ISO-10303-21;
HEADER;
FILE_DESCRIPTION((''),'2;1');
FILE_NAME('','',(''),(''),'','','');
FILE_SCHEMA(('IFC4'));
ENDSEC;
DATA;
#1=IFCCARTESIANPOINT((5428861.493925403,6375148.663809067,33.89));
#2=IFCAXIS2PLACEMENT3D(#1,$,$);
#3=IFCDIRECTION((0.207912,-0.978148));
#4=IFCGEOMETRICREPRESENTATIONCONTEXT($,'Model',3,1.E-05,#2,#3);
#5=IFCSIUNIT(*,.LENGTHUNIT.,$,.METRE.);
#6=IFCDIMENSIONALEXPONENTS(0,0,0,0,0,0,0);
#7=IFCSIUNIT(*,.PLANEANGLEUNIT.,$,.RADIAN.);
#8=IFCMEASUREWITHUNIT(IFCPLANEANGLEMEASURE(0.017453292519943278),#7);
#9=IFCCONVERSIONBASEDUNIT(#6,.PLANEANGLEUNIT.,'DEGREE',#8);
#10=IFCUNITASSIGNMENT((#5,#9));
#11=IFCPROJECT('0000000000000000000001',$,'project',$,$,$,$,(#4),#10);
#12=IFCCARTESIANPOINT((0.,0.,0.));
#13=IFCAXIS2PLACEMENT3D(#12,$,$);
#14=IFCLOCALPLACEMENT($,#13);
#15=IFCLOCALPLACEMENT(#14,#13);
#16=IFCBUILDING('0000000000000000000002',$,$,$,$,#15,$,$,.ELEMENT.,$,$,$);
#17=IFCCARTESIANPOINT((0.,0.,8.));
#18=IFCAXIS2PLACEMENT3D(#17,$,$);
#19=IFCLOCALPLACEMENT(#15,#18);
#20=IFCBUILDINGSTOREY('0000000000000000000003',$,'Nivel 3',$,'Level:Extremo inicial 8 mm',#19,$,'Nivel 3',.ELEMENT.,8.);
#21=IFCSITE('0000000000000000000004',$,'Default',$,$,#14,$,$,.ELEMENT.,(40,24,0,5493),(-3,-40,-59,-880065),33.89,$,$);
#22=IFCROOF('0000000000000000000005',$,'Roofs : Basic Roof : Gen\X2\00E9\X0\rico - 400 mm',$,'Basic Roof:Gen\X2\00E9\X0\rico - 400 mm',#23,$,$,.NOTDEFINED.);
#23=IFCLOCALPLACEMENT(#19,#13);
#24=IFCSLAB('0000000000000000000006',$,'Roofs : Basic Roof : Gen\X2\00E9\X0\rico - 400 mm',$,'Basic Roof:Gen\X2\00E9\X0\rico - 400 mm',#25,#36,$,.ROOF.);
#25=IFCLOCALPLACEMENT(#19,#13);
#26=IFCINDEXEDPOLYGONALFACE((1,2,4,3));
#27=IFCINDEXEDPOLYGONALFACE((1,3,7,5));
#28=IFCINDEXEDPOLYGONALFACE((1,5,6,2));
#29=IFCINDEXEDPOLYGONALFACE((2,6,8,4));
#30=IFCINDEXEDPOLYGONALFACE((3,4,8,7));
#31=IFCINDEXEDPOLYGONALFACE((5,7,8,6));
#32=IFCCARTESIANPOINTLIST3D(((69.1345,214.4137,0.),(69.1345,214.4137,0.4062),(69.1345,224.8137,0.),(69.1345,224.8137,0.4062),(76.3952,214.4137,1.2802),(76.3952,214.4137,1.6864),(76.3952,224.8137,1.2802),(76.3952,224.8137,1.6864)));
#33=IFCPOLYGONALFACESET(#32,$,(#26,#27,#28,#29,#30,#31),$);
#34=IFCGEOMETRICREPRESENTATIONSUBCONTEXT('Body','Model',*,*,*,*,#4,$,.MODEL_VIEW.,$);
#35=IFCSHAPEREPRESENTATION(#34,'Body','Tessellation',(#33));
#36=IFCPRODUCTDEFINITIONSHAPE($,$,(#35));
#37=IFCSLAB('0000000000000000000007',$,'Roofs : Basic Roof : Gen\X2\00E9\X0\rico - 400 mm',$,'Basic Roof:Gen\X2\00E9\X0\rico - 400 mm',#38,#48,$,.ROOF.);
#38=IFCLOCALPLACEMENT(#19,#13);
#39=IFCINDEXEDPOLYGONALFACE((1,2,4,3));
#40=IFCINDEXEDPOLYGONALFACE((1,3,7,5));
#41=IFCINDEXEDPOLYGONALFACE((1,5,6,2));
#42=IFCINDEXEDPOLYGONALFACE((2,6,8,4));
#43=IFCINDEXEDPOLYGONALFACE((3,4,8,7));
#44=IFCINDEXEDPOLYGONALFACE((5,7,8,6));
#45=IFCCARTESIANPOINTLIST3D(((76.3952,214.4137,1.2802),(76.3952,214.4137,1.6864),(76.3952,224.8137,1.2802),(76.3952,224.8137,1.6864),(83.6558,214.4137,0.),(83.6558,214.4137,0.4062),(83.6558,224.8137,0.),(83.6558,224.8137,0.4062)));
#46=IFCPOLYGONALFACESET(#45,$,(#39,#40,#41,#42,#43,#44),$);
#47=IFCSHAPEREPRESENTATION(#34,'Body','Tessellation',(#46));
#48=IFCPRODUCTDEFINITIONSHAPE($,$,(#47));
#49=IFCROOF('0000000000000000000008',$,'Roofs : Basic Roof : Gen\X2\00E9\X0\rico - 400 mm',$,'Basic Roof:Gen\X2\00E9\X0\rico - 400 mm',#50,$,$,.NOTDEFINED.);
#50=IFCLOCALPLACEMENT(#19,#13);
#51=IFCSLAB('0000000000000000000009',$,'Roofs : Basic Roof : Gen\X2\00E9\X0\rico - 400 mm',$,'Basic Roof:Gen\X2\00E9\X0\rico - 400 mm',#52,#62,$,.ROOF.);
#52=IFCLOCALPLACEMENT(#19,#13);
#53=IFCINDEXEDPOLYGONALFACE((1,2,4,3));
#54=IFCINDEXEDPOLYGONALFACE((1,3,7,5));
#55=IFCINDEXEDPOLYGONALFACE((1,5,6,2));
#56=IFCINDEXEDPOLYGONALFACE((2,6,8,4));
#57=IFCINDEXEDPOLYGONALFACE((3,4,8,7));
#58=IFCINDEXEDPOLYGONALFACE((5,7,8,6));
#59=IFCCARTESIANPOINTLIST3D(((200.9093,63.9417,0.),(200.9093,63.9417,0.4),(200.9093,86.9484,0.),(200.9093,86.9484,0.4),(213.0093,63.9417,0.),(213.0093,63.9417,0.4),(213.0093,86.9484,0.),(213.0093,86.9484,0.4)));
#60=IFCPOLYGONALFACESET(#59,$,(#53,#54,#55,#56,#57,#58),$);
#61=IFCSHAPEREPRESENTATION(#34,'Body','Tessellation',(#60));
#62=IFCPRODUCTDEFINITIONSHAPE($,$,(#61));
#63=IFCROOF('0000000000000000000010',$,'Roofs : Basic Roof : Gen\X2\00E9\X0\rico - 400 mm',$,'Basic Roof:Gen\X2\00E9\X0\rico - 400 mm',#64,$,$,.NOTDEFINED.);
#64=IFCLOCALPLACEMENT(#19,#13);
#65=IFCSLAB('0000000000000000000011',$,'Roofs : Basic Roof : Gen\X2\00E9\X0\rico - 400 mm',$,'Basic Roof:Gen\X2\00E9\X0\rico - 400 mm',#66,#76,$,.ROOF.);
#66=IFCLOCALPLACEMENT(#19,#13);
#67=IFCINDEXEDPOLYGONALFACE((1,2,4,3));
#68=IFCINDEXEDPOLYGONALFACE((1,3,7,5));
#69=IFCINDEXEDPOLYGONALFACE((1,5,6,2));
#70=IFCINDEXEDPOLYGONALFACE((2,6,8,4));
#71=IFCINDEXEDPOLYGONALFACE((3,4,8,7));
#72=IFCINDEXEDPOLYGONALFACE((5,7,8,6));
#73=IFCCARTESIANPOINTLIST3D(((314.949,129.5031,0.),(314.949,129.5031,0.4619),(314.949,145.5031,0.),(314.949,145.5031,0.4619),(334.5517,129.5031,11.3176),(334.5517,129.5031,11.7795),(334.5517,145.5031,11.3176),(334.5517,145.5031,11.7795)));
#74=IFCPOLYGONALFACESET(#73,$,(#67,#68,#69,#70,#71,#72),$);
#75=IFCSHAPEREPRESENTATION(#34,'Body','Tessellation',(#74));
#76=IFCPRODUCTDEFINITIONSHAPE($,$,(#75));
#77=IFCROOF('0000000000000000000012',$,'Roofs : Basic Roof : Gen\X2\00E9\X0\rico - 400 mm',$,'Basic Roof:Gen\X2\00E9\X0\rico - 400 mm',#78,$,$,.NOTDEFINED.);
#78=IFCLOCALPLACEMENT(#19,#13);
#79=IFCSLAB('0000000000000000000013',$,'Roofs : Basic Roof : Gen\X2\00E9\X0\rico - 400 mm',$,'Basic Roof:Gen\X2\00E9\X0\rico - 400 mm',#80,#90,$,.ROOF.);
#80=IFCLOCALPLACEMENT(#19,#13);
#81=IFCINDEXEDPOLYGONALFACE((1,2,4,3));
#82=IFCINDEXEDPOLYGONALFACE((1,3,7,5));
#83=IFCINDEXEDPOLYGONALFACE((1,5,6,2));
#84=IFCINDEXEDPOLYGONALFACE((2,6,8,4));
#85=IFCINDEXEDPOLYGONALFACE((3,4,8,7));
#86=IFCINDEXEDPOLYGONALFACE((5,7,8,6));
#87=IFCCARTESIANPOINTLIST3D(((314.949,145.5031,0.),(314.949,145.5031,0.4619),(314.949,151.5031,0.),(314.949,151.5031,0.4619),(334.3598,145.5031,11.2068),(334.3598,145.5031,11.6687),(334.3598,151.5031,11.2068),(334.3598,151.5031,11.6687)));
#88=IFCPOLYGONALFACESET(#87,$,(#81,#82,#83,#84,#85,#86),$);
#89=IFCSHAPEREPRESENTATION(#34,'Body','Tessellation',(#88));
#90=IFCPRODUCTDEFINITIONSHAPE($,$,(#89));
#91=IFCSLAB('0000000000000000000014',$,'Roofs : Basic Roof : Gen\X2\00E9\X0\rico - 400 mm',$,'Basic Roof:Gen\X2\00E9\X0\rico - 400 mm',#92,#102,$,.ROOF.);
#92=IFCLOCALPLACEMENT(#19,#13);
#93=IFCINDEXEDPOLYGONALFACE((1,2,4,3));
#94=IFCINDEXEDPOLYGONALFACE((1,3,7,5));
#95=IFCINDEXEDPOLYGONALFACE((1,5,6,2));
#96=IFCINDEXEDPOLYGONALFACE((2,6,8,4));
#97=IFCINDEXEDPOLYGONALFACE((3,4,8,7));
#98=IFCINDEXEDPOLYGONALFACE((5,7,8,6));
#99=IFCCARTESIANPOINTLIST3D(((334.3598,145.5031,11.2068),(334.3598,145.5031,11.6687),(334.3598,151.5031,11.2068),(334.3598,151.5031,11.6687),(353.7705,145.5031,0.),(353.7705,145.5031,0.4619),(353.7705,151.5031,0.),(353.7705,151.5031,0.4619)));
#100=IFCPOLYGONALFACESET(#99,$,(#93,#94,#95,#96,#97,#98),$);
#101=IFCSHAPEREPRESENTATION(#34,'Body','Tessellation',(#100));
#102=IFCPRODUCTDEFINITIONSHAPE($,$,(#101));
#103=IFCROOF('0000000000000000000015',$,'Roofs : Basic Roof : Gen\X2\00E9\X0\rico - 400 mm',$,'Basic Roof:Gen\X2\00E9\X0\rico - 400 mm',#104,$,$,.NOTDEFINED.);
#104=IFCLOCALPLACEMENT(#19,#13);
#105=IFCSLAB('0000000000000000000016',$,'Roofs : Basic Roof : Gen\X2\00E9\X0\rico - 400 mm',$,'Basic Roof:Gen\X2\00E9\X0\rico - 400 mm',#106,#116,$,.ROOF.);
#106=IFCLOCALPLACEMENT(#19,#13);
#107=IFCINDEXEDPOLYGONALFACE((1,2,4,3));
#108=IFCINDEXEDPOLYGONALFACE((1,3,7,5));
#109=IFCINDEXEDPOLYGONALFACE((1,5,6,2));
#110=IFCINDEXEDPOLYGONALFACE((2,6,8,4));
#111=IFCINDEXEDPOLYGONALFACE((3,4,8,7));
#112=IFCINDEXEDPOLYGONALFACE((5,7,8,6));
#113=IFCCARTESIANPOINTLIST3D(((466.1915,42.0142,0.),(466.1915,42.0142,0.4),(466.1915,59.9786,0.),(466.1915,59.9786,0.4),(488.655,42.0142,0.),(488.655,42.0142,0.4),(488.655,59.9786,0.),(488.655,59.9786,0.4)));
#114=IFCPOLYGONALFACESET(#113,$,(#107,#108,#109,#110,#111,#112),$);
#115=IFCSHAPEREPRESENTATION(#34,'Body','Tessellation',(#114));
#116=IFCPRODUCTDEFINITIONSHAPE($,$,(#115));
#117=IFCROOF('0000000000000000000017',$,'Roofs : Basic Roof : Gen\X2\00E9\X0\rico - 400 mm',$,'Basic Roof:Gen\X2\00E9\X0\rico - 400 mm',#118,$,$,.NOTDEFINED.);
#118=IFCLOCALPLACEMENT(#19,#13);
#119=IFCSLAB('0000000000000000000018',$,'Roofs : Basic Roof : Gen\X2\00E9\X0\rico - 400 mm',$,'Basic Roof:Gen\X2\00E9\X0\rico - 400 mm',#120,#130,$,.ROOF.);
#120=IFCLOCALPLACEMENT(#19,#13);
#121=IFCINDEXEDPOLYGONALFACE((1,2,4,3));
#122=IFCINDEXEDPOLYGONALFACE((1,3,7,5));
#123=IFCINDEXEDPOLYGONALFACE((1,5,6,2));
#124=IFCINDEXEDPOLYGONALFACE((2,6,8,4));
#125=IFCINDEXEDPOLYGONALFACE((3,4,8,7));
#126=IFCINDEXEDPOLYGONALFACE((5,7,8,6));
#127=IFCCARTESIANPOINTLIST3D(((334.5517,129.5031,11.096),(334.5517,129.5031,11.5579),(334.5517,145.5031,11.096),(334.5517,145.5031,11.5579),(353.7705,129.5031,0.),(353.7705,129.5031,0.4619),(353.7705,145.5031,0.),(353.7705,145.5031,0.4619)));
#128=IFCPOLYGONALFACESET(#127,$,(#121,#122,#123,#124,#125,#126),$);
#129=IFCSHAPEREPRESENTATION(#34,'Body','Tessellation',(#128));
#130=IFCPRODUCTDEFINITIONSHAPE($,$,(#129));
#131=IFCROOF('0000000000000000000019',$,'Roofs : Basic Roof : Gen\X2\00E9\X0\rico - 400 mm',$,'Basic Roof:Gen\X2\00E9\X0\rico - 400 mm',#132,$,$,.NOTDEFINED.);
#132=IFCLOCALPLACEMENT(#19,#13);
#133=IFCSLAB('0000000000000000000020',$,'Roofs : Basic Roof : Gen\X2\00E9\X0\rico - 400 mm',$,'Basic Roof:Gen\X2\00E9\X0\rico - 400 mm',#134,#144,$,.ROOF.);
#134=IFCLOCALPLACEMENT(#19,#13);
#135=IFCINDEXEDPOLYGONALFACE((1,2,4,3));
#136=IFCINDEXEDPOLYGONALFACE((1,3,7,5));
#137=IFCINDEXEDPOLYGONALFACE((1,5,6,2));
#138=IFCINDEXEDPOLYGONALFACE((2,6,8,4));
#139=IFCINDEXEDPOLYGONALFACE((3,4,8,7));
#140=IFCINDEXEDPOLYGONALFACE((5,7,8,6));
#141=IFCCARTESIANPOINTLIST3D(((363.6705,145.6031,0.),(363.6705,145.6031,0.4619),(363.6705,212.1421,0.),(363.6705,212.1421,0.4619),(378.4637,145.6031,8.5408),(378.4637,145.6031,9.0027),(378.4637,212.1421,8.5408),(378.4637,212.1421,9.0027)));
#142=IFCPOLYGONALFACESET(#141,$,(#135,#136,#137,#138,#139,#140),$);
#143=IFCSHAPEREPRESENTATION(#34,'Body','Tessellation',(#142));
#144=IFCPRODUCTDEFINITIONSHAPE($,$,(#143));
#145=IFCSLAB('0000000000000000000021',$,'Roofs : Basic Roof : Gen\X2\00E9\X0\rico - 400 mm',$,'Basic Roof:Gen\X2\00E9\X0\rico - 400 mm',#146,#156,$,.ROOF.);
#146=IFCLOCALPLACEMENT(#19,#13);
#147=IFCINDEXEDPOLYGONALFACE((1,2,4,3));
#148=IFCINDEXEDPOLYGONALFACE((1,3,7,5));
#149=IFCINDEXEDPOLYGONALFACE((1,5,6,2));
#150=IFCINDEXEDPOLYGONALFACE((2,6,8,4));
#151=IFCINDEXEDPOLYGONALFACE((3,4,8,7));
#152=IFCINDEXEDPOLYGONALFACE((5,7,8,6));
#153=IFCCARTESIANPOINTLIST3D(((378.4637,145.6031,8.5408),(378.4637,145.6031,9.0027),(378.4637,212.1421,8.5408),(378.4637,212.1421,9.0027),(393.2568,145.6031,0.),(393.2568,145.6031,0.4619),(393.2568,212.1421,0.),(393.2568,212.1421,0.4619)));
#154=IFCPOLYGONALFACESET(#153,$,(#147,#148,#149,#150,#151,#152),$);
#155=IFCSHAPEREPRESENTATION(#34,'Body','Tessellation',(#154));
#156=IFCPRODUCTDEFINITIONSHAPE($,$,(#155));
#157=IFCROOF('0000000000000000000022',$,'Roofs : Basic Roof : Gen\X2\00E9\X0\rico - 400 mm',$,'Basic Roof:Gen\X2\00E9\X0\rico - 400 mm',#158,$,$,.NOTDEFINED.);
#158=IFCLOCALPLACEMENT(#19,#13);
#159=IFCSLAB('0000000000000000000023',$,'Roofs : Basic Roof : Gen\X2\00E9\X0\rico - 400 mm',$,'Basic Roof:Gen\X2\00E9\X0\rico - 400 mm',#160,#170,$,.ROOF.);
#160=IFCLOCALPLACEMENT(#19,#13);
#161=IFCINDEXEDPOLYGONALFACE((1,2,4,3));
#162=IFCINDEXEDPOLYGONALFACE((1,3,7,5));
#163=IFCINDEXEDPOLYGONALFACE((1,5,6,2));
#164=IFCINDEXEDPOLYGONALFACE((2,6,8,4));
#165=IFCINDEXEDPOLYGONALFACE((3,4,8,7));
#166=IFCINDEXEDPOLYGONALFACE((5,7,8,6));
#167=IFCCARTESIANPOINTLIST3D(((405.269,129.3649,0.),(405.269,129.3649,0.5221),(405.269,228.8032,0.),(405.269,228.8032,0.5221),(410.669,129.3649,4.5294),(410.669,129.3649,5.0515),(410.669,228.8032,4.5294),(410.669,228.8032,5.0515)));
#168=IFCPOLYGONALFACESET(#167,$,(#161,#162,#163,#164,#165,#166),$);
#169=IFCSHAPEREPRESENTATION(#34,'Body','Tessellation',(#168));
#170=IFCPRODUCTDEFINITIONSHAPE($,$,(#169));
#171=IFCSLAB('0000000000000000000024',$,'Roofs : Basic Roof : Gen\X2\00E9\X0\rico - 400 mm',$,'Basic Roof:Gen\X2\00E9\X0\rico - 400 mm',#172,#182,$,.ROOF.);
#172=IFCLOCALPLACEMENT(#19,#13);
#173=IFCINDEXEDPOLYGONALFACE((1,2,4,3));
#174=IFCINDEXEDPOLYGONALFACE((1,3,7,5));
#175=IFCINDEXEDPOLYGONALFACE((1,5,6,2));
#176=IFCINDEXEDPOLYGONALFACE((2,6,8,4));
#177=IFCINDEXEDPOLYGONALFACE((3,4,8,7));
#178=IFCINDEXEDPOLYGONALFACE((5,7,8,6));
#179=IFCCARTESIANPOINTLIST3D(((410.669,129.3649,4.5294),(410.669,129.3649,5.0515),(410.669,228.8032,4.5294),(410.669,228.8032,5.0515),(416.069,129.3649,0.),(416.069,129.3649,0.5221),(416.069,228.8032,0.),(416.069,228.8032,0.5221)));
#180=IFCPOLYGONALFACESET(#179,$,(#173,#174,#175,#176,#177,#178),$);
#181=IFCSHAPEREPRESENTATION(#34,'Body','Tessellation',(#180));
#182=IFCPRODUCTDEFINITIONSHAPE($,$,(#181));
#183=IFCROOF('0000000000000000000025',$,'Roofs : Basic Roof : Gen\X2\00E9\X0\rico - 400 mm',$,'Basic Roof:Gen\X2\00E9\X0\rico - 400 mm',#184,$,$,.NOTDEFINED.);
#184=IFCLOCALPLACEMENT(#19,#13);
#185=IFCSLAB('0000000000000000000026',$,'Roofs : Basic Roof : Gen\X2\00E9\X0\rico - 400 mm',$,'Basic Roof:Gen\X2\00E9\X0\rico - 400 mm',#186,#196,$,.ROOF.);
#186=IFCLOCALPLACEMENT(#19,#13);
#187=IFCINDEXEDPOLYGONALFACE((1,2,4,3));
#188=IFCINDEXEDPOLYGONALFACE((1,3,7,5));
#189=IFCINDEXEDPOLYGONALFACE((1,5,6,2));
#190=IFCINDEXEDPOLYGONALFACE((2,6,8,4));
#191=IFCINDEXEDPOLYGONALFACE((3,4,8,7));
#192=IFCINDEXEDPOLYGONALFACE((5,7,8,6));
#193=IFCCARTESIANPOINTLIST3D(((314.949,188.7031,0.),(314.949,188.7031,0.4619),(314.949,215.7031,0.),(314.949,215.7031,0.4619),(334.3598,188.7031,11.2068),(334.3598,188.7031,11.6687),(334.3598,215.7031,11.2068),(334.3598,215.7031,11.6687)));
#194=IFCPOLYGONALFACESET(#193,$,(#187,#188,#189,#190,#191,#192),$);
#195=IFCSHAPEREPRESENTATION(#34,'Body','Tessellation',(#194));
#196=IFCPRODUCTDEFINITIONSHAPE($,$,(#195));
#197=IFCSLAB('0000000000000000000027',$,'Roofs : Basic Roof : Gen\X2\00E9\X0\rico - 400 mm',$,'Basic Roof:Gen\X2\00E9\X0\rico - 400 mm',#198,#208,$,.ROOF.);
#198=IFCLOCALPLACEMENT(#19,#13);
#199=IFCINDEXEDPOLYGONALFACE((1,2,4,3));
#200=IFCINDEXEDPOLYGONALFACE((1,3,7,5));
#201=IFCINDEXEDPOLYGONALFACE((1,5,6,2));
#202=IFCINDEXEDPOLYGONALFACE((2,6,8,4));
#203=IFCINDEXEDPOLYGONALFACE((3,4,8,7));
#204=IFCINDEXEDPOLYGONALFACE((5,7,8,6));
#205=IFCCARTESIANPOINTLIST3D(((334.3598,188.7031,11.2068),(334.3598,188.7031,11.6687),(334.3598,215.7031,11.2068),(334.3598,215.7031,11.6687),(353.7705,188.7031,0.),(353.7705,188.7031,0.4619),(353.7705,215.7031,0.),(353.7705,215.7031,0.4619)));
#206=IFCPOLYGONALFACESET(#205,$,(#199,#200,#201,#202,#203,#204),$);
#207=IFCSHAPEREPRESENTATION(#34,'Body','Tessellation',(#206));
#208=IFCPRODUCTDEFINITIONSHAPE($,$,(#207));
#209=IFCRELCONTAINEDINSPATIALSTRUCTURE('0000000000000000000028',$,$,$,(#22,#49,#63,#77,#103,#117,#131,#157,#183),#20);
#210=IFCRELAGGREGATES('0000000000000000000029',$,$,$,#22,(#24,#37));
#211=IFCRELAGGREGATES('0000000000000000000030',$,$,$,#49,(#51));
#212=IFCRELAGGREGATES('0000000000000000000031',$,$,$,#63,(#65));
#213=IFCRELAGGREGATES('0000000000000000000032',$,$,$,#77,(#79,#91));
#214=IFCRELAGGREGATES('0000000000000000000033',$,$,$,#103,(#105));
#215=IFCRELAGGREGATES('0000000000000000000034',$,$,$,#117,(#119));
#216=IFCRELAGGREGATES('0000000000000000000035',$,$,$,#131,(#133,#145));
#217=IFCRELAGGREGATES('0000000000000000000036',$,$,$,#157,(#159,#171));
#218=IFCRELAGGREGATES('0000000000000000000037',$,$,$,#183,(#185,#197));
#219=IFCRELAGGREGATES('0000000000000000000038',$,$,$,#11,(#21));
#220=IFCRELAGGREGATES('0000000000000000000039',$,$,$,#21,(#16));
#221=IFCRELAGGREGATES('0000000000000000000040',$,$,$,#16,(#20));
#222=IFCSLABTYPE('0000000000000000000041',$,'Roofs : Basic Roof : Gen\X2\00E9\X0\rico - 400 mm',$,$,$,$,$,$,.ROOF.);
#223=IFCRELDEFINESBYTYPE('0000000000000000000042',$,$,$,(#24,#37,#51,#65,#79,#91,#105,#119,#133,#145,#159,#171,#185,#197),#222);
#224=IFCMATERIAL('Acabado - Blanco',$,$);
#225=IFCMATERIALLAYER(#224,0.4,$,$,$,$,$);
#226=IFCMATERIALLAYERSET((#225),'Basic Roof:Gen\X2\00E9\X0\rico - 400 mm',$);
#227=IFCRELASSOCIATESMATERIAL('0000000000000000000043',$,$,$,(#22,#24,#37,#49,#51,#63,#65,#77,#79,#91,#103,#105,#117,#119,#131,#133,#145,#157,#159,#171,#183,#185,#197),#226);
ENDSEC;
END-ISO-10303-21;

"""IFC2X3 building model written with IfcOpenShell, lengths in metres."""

from ifc_helpers import new_model, entity, si_unit, converted_unit, direction, frame, frame_2d, origin, origin_2d_with_axis, place, context, subcontext, project, spatial, rectangle, extrude, material, layer, layer_set, type_object, element, aggregate, save


model = new_model("IFC2X3")

# Units and contexts
model_context = context("Model", 3, precision=1e-05, world=frame((5428861.493925403, 6375148.663809067, 33.89)), true_north=direction((0.207912, -0.978148)))
body_context = subcontext(model_context, "Body", "Model", "MODEL_VIEW")
ifc_project = project(units=[si_unit("LENGTHUNIT", "METRE"), converted_unit("PLANEANGLEUNIT", "DEGREE", entity("IfcPlaneAngleMeasure", 0.017453292519943278), si_unit("PLANEANGLEUNIT", "RADIAN"), dimensions=[0, 0, 0, 0, 0, 0, 0])], contexts=[model_context])

# Site, building, storey
site_placement = place(None, origin())
site = spatial("IfcSite", under=ifc_project, at=site_placement, Name="Default", CompositionType="ELEMENT", RefLatitude=(40, 24, 0, 5493), RefLongitude=(-3, -40, -59, -880065), RefElevation=33.89)
building_placement = place(site_placement, origin())
building = spatial("IfcBuilding", under=site, at=building_placement, CompositionType="ELEMENT")
storey_placement = place(building_placement, frame((0.0, 0.0, 8.0)))
storey = spatial("IfcBuildingStorey", under=building, at=storey_placement, Name="Nivel 3", ObjectType="Level:Extremo inicial 8 mm", LongName="Nivel 3", CompositionType="ELEMENT", Elevation=8.0)

# Roof, slabs
ifc_material = material(Name="Acabado - Blanco")
ifc_layer = layer(ifc_material, 0.4)
ifc_layer_set = layer_set([ifc_layer], Name="Basic Roof:Genérico - 400 mm")
slab_type = type_object("IfcSlabType", Name="Roofs : Basic Roof : Genérico - 400 mm", PredefinedType="ROOF")
roof_1_placement = place(storey_placement, frame((69.1345, 214.4137, 0.0)))
roof_1 = element("IfcRoof", 1, at=roof_1_placement, inside=storey, material=ifc_layer_set, Name="Roofs : Basic Roof : Genérico - 400 mm", ObjectType="Basic Roof:Genérico - 400 mm", ShapeType="NOTDEFINED")
slab_1_placement = place(roof_1_placement, origin())
slab_1 = element("IfcSlab", 2, at=slab_1_placement, type_object=slab_type, material=ifc_layer_set, Name="Roofs : Basic Roof : Genérico - 400 mm", ObjectType="Basic Roof:Genérico - 400 mm", PredefinedType="ROOF", context=body_context, shape_type="SweptSolid", body=[
    extrude(rectangle(XDim=10.4, YDim=7.3726, at=frame_2d((0.0, 0.0), x_axis=(0.0, 1.0))), frame((3.6303, 5.2, 0.6401), z_axis=(-0.173648, 0.0, 0.984808), x_axis=(0.984808, 0.0, 0.173648)), (0.173648, 0.0, 0.984808), 0.4062),
])
slab_2_placement = place(roof_1_placement, origin())
slab_2 = element("IfcSlab", 3, at=slab_2_placement, type_object=slab_type, material=ifc_layer_set, Name="Roofs : Basic Roof : Genérico - 400 mm", ObjectType="Basic Roof:Genérico - 400 mm", PredefinedType="ROOF", context=body_context, shape_type="SweptSolid", body=[
    extrude(rectangle(XDim=7.3726, YDim=10.4, at=frame_2d((0.0, 0.0), x_axis=(1.0, 0.0))), frame((10.8909, 5.2, 0.6401), z_axis=(0.173648, 0.0, 0.984808), x_axis=(0.984808, 0.0, -0.173648)), (-0.173648, 0.0, 0.984808), 0.4062),
])
aggregate(roof_1, [slab_1, slab_2])

# Roofs, slabs
roof_2_placement = place(storey_placement, frame((200.9093, 63.9417, 0.0)))
roof_2 = element("IfcRoof", 4, at=roof_2_placement, inside=storey, material=ifc_layer_set, Name="Roofs : Basic Roof : Genérico - 400 mm", ObjectType="Basic Roof:Genérico - 400 mm", ShapeType="NOTDEFINED")
slab_3_placement = place(roof_2_placement, origin())
slab_3 = element("IfcSlab", 5, at=slab_3_placement, type_object=slab_type, material=ifc_layer_set, Name="Roofs : Basic Roof : Genérico - 400 mm", ObjectType="Basic Roof:Genérico - 400 mm", PredefinedType="ROOF", context=body_context, shape_type="SweptSolid", body=[
    extrude(rectangle(XDim=12.1, YDim=23.0067, at=frame_2d((0.0, 0.0), x_axis=(1.0, 0.0))), frame((6.05, 11.5033, 0.0)), (0.0, 0.0, 1.0), 0.4),
])
aggregate(roof_2, [slab_3])
roof_3_placement = place(storey_placement, frame((314.949, 129.5031, 0.0)))
roof_3 = element("IfcRoof", 6, at=roof_3_placement, inside=storey, material=ifc_layer_set, Name="Roofs : Basic Roof : Genérico - 400 mm", ObjectType="Basic Roof:Genérico - 400 mm", ShapeType="NOTDEFINED")
slab_4_placement = place(roof_3_placement, origin())
slab_4 = element("IfcSlab", 7, at=slab_4_placement, type_object=slab_type, material=ifc_layer_set, Name="Roofs : Basic Roof : Genérico - 400 mm", ObjectType="Basic Roof:Genérico - 400 mm", PredefinedType="ROOF", context=body_context, shape_type="SweptSolid", body=[
    extrude(rectangle(XDim=22.6353, YDim=16.0, at=origin_2d_with_axis()), frame((9.8014, 8.0, 5.6588), z_axis=(-0.5, 0.0, 0.866025), x_axis=(0.866025, 0.0, 0.5)), (0.5, 0.0, 0.866025), 0.4619),
])
aggregate(roof_3, [slab_4])

# Roof, slabs
roof_4_placement = place(storey_placement, frame((314.949, 145.5031, 0.0)))
roof_4 = element("IfcRoof", 8, at=roof_4_placement, inside=storey, material=ifc_layer_set, Name="Roofs : Basic Roof : Genérico - 400 mm", ObjectType="Basic Roof:Genérico - 400 mm", ShapeType="NOTDEFINED")
slab_5_placement = place(roof_4_placement, origin())
slab_5 = element("IfcSlab", 9, at=slab_5_placement, type_object=slab_type, material=ifc_layer_set, Name="Roofs : Basic Roof : Genérico - 400 mm", ObjectType="Basic Roof:Genérico - 400 mm", PredefinedType="ROOF", context=body_context, shape_type="SweptSolid", body=[
    extrude(rectangle(XDim=6.0, YDim=22.4136, at=frame_2d((0.0, 0.0), x_axis=(0.0, 1.0))), frame((9.7054, 3.0, 5.6034), z_axis=(-0.5, 0.0, 0.866025), x_axis=(0.866025, 0.0, 0.5)), (0.5, 0.0, 0.866025), 0.4619),
])
slab_6_placement = place(roof_4_placement, origin())
slab_6 = element("IfcSlab", 10, at=slab_6_placement, type_object=slab_type, material=ifc_layer_set, Name="Roofs : Basic Roof : Genérico - 400 mm", ObjectType="Basic Roof:Genérico - 400 mm", PredefinedType="ROOF", context=body_context, shape_type="SweptSolid", body=[
    extrude(rectangle(XDim=22.4136, YDim=6.0, at=frame_2d((0.0, 0.0), x_axis=(1.0, 0.0))), frame((29.1162, 3.0, 5.6034), z_axis=(0.5, 0.0, 0.866025), x_axis=(0.866025, 0.0, -0.5)), (-0.5, 0.0, 0.866025), 0.4619),
])
aggregate(roof_4, [slab_5, slab_6])

# Roofs, slabs
roof_5_placement = place(storey_placement, frame((466.1915, 42.0142, 0.0)))
roof_5 = element("IfcRoof", 11, at=roof_5_placement, inside=storey, material=ifc_layer_set, Name="Roofs : Basic Roof : Genérico - 400 mm", ObjectType="Basic Roof:Genérico - 400 mm", ShapeType="NOTDEFINED")
slab_7_placement = place(roof_5_placement, origin())
slab_7 = element("IfcSlab", 12, at=slab_7_placement, type_object=slab_type, material=ifc_layer_set, Name="Roofs : Basic Roof : Genérico - 400 mm", ObjectType="Basic Roof:Genérico - 400 mm", PredefinedType="ROOF", context=body_context, shape_type="SweptSolid", body=[
    extrude(rectangle(XDim=22.4635, YDim=17.9644, at=frame_2d((0.0, 0.0), x_axis=(1.0, 0.0))), frame((11.2317, 8.9822, 0.0)), (0.0, 0.0, 1.0), 0.4),
])
aggregate(roof_5, [slab_7])
roof_6_placement = place(storey_placement, frame((334.5517, 129.5031, 0.0)))
roof_6 = element("IfcRoof", 13, at=roof_6_placement, inside=storey, material=ifc_layer_set, Name="Roofs : Basic Roof : Genérico - 400 mm", ObjectType="Basic Roof:Genérico - 400 mm", ShapeType="NOTDEFINED")
slab_8_placement = place(roof_6_placement, origin())
slab_8 = element("IfcSlab", 14, at=slab_8_placement, type_object=slab_type, material=ifc_layer_set, Name="Roofs : Basic Roof : Genérico - 400 mm", ObjectType="Basic Roof:Genérico - 400 mm", PredefinedType="ROOF", context=body_context, shape_type="SweptSolid", body=[
    extrude(rectangle(XDim=16.0, YDim=22.192, at=frame_2d((0.0, 0.0), x_axis=(0.0, 1.0))), frame((9.6094, 8.0, 5.548), z_axis=(0.5, 0.0, 0.866025), x_axis=(0.866025, 0.0, -0.5)), (-0.5, 0.0, 0.866025), 0.4619),
])
aggregate(roof_6, [slab_8])

# Roofs, slabs
roof_7_placement = place(storey_placement, frame((363.6705, 145.6031, 0.0)))
roof_7 = element("IfcRoof", 15, at=roof_7_placement, inside=storey, material=ifc_layer_set, Name="Roofs : Basic Roof : Genérico - 400 mm", ObjectType="Basic Roof:Genérico - 400 mm", ShapeType="NOTDEFINED")
slab_9_placement = place(roof_7_placement, origin())
slab_9 = element("IfcSlab", 16, at=slab_9_placement, type_object=slab_type, material=ifc_layer_set, Name="Roofs : Basic Roof : Genérico - 400 mm", ObjectType="Basic Roof:Genérico - 400 mm", PredefinedType="ROOF", context=body_context, shape_type="SweptSolid", body=[
    extrude(rectangle(XDim=66.5389, YDim=17.0816, at=frame_2d((0.0, 0.0), x_axis=(0.0, 1.0))), frame((7.3966, 33.2695, 4.2704), z_axis=(-0.5, 0.0, 0.866025), x_axis=(0.866025, 0.0, 0.5)), (0.5, 0.0, 0.866025), 0.4619),
])
slab_10_placement = place(roof_7_placement, origin())
slab_10 = element("IfcSlab", 17, at=slab_10_placement, type_object=slab_type, material=ifc_layer_set, Name="Roofs : Basic Roof : Genérico - 400 mm", ObjectType="Basic Roof:Genérico - 400 mm", PredefinedType="ROOF", context=body_context, shape_type="SweptSolid", body=[
    extrude(rectangle(XDim=17.0816, YDim=66.5389, at=origin_2d_with_axis()), frame((22.1897, 33.2695, 4.2704), z_axis=(0.5, 0.0, 0.866025), x_axis=(0.866025, 0.0, -0.5)), (-0.5, 0.0, 0.866025), 0.4619),
])
aggregate(roof_7, [slab_9, slab_10])
roof_8_placement = place(storey_placement, frame((405.269, 129.3649, 0.0)))
roof_8 = element("IfcRoof", 18, at=roof_8_placement, inside=storey, material=ifc_layer_set, Name="Roofs : Basic Roof : Genérico - 400 mm", ObjectType="Basic Roof:Genérico - 400 mm", ShapeType="NOTDEFINED")
slab_11_placement = place(roof_8_placement, origin())
slab_11 = element("IfcSlab", 19, at=slab_11_placement, type_object=slab_type, material=ifc_layer_set, Name="Roofs : Basic Roof : Genérico - 400 mm", ObjectType="Basic Roof:Genérico - 400 mm", PredefinedType="ROOF", context=body_context, shape_type="SweptSolid", body=[
    extrude(rectangle(XDim=99.4383, YDim=7.0481, at=frame_2d((0.0, 0.0), x_axis=(0.0, 1.0))), frame((2.7, 49.7191, 2.2647), z_axis=(-0.642641, 0.0, 0.766167), x_axis=(0.766167, 0.0, 0.642641)), (0.642641, 0.0, 0.766167), 0.5221),
])
slab_12_placement = place(roof_8_placement, origin())
slab_12 = element("IfcSlab", 20, at=slab_12_placement, type_object=slab_type, material=ifc_layer_set, Name="Roofs : Basic Roof : Genérico - 400 mm", ObjectType="Basic Roof:Genérico - 400 mm", PredefinedType="ROOF", context=body_context, shape_type="SweptSolid", body=[
    extrude(rectangle(XDim=7.0481, YDim=99.4383, at=frame_2d((0.0, 0.0), x_axis=(1.0, 0.0))), frame((8.1, 49.7191, 2.2647), z_axis=(0.642641, 0.0, 0.766167), x_axis=(0.766167, 0.0, -0.642641)), (-0.642641, 0.0, 0.766167), 0.5221),
])
aggregate(roof_8, [slab_11, slab_12])
roof_9_placement = place(storey_placement, frame((314.949, 188.7031, 0.0)))
roof_9 = element("IfcRoof", 21, at=roof_9_placement, inside=storey, material=ifc_layer_set, Name="Roofs : Basic Roof : Genérico - 400 mm", ObjectType="Basic Roof:Genérico - 400 mm", ShapeType="NOTDEFINED")
slab_13_placement = place(roof_9_placement, origin())
slab_13 = element("IfcSlab", 22, at=slab_13_placement, type_object=slab_type, material=ifc_layer_set, Name="Roofs : Basic Roof : Genérico - 400 mm", ObjectType="Basic Roof:Genérico - 400 mm", PredefinedType="ROOF", context=body_context, shape_type="SweptSolid", body=[
    extrude(rectangle(XDim=27.0, YDim=22.4136, at=frame_2d((0.0, 0.0), x_axis=(0.0, 1.0))), frame((9.7054, 13.5, 5.6034), z_axis=(-0.5, 0.0, 0.866025), x_axis=(0.866025, 0.0, 0.5)), (0.5, 0.0, 0.866025), 0.4619),
])
slab_14_placement = place(roof_9_placement, origin())
slab_14 = element("IfcSlab", 23, at=slab_14_placement, type_object=slab_type, material=ifc_layer_set, Name="Roofs : Basic Roof : Genérico - 400 mm", ObjectType="Basic Roof:Genérico - 400 mm", PredefinedType="ROOF", context=body_context, shape_type="SweptSolid", body=[
    extrude(rectangle(XDim=22.4136, YDim=27.0, at=frame_2d((0.0, 0.0), x_axis=(1.0, 0.0))), frame((29.1162, 13.5, 5.6034), z_axis=(0.5, 0.0, 0.866025), x_axis=(0.866025, 0.0, -0.5)), (-0.5, 0.0, 0.866025), 0.4619),
])
aggregate(roof_9, [slab_13, slab_14])

save(model, "model.ifc")
